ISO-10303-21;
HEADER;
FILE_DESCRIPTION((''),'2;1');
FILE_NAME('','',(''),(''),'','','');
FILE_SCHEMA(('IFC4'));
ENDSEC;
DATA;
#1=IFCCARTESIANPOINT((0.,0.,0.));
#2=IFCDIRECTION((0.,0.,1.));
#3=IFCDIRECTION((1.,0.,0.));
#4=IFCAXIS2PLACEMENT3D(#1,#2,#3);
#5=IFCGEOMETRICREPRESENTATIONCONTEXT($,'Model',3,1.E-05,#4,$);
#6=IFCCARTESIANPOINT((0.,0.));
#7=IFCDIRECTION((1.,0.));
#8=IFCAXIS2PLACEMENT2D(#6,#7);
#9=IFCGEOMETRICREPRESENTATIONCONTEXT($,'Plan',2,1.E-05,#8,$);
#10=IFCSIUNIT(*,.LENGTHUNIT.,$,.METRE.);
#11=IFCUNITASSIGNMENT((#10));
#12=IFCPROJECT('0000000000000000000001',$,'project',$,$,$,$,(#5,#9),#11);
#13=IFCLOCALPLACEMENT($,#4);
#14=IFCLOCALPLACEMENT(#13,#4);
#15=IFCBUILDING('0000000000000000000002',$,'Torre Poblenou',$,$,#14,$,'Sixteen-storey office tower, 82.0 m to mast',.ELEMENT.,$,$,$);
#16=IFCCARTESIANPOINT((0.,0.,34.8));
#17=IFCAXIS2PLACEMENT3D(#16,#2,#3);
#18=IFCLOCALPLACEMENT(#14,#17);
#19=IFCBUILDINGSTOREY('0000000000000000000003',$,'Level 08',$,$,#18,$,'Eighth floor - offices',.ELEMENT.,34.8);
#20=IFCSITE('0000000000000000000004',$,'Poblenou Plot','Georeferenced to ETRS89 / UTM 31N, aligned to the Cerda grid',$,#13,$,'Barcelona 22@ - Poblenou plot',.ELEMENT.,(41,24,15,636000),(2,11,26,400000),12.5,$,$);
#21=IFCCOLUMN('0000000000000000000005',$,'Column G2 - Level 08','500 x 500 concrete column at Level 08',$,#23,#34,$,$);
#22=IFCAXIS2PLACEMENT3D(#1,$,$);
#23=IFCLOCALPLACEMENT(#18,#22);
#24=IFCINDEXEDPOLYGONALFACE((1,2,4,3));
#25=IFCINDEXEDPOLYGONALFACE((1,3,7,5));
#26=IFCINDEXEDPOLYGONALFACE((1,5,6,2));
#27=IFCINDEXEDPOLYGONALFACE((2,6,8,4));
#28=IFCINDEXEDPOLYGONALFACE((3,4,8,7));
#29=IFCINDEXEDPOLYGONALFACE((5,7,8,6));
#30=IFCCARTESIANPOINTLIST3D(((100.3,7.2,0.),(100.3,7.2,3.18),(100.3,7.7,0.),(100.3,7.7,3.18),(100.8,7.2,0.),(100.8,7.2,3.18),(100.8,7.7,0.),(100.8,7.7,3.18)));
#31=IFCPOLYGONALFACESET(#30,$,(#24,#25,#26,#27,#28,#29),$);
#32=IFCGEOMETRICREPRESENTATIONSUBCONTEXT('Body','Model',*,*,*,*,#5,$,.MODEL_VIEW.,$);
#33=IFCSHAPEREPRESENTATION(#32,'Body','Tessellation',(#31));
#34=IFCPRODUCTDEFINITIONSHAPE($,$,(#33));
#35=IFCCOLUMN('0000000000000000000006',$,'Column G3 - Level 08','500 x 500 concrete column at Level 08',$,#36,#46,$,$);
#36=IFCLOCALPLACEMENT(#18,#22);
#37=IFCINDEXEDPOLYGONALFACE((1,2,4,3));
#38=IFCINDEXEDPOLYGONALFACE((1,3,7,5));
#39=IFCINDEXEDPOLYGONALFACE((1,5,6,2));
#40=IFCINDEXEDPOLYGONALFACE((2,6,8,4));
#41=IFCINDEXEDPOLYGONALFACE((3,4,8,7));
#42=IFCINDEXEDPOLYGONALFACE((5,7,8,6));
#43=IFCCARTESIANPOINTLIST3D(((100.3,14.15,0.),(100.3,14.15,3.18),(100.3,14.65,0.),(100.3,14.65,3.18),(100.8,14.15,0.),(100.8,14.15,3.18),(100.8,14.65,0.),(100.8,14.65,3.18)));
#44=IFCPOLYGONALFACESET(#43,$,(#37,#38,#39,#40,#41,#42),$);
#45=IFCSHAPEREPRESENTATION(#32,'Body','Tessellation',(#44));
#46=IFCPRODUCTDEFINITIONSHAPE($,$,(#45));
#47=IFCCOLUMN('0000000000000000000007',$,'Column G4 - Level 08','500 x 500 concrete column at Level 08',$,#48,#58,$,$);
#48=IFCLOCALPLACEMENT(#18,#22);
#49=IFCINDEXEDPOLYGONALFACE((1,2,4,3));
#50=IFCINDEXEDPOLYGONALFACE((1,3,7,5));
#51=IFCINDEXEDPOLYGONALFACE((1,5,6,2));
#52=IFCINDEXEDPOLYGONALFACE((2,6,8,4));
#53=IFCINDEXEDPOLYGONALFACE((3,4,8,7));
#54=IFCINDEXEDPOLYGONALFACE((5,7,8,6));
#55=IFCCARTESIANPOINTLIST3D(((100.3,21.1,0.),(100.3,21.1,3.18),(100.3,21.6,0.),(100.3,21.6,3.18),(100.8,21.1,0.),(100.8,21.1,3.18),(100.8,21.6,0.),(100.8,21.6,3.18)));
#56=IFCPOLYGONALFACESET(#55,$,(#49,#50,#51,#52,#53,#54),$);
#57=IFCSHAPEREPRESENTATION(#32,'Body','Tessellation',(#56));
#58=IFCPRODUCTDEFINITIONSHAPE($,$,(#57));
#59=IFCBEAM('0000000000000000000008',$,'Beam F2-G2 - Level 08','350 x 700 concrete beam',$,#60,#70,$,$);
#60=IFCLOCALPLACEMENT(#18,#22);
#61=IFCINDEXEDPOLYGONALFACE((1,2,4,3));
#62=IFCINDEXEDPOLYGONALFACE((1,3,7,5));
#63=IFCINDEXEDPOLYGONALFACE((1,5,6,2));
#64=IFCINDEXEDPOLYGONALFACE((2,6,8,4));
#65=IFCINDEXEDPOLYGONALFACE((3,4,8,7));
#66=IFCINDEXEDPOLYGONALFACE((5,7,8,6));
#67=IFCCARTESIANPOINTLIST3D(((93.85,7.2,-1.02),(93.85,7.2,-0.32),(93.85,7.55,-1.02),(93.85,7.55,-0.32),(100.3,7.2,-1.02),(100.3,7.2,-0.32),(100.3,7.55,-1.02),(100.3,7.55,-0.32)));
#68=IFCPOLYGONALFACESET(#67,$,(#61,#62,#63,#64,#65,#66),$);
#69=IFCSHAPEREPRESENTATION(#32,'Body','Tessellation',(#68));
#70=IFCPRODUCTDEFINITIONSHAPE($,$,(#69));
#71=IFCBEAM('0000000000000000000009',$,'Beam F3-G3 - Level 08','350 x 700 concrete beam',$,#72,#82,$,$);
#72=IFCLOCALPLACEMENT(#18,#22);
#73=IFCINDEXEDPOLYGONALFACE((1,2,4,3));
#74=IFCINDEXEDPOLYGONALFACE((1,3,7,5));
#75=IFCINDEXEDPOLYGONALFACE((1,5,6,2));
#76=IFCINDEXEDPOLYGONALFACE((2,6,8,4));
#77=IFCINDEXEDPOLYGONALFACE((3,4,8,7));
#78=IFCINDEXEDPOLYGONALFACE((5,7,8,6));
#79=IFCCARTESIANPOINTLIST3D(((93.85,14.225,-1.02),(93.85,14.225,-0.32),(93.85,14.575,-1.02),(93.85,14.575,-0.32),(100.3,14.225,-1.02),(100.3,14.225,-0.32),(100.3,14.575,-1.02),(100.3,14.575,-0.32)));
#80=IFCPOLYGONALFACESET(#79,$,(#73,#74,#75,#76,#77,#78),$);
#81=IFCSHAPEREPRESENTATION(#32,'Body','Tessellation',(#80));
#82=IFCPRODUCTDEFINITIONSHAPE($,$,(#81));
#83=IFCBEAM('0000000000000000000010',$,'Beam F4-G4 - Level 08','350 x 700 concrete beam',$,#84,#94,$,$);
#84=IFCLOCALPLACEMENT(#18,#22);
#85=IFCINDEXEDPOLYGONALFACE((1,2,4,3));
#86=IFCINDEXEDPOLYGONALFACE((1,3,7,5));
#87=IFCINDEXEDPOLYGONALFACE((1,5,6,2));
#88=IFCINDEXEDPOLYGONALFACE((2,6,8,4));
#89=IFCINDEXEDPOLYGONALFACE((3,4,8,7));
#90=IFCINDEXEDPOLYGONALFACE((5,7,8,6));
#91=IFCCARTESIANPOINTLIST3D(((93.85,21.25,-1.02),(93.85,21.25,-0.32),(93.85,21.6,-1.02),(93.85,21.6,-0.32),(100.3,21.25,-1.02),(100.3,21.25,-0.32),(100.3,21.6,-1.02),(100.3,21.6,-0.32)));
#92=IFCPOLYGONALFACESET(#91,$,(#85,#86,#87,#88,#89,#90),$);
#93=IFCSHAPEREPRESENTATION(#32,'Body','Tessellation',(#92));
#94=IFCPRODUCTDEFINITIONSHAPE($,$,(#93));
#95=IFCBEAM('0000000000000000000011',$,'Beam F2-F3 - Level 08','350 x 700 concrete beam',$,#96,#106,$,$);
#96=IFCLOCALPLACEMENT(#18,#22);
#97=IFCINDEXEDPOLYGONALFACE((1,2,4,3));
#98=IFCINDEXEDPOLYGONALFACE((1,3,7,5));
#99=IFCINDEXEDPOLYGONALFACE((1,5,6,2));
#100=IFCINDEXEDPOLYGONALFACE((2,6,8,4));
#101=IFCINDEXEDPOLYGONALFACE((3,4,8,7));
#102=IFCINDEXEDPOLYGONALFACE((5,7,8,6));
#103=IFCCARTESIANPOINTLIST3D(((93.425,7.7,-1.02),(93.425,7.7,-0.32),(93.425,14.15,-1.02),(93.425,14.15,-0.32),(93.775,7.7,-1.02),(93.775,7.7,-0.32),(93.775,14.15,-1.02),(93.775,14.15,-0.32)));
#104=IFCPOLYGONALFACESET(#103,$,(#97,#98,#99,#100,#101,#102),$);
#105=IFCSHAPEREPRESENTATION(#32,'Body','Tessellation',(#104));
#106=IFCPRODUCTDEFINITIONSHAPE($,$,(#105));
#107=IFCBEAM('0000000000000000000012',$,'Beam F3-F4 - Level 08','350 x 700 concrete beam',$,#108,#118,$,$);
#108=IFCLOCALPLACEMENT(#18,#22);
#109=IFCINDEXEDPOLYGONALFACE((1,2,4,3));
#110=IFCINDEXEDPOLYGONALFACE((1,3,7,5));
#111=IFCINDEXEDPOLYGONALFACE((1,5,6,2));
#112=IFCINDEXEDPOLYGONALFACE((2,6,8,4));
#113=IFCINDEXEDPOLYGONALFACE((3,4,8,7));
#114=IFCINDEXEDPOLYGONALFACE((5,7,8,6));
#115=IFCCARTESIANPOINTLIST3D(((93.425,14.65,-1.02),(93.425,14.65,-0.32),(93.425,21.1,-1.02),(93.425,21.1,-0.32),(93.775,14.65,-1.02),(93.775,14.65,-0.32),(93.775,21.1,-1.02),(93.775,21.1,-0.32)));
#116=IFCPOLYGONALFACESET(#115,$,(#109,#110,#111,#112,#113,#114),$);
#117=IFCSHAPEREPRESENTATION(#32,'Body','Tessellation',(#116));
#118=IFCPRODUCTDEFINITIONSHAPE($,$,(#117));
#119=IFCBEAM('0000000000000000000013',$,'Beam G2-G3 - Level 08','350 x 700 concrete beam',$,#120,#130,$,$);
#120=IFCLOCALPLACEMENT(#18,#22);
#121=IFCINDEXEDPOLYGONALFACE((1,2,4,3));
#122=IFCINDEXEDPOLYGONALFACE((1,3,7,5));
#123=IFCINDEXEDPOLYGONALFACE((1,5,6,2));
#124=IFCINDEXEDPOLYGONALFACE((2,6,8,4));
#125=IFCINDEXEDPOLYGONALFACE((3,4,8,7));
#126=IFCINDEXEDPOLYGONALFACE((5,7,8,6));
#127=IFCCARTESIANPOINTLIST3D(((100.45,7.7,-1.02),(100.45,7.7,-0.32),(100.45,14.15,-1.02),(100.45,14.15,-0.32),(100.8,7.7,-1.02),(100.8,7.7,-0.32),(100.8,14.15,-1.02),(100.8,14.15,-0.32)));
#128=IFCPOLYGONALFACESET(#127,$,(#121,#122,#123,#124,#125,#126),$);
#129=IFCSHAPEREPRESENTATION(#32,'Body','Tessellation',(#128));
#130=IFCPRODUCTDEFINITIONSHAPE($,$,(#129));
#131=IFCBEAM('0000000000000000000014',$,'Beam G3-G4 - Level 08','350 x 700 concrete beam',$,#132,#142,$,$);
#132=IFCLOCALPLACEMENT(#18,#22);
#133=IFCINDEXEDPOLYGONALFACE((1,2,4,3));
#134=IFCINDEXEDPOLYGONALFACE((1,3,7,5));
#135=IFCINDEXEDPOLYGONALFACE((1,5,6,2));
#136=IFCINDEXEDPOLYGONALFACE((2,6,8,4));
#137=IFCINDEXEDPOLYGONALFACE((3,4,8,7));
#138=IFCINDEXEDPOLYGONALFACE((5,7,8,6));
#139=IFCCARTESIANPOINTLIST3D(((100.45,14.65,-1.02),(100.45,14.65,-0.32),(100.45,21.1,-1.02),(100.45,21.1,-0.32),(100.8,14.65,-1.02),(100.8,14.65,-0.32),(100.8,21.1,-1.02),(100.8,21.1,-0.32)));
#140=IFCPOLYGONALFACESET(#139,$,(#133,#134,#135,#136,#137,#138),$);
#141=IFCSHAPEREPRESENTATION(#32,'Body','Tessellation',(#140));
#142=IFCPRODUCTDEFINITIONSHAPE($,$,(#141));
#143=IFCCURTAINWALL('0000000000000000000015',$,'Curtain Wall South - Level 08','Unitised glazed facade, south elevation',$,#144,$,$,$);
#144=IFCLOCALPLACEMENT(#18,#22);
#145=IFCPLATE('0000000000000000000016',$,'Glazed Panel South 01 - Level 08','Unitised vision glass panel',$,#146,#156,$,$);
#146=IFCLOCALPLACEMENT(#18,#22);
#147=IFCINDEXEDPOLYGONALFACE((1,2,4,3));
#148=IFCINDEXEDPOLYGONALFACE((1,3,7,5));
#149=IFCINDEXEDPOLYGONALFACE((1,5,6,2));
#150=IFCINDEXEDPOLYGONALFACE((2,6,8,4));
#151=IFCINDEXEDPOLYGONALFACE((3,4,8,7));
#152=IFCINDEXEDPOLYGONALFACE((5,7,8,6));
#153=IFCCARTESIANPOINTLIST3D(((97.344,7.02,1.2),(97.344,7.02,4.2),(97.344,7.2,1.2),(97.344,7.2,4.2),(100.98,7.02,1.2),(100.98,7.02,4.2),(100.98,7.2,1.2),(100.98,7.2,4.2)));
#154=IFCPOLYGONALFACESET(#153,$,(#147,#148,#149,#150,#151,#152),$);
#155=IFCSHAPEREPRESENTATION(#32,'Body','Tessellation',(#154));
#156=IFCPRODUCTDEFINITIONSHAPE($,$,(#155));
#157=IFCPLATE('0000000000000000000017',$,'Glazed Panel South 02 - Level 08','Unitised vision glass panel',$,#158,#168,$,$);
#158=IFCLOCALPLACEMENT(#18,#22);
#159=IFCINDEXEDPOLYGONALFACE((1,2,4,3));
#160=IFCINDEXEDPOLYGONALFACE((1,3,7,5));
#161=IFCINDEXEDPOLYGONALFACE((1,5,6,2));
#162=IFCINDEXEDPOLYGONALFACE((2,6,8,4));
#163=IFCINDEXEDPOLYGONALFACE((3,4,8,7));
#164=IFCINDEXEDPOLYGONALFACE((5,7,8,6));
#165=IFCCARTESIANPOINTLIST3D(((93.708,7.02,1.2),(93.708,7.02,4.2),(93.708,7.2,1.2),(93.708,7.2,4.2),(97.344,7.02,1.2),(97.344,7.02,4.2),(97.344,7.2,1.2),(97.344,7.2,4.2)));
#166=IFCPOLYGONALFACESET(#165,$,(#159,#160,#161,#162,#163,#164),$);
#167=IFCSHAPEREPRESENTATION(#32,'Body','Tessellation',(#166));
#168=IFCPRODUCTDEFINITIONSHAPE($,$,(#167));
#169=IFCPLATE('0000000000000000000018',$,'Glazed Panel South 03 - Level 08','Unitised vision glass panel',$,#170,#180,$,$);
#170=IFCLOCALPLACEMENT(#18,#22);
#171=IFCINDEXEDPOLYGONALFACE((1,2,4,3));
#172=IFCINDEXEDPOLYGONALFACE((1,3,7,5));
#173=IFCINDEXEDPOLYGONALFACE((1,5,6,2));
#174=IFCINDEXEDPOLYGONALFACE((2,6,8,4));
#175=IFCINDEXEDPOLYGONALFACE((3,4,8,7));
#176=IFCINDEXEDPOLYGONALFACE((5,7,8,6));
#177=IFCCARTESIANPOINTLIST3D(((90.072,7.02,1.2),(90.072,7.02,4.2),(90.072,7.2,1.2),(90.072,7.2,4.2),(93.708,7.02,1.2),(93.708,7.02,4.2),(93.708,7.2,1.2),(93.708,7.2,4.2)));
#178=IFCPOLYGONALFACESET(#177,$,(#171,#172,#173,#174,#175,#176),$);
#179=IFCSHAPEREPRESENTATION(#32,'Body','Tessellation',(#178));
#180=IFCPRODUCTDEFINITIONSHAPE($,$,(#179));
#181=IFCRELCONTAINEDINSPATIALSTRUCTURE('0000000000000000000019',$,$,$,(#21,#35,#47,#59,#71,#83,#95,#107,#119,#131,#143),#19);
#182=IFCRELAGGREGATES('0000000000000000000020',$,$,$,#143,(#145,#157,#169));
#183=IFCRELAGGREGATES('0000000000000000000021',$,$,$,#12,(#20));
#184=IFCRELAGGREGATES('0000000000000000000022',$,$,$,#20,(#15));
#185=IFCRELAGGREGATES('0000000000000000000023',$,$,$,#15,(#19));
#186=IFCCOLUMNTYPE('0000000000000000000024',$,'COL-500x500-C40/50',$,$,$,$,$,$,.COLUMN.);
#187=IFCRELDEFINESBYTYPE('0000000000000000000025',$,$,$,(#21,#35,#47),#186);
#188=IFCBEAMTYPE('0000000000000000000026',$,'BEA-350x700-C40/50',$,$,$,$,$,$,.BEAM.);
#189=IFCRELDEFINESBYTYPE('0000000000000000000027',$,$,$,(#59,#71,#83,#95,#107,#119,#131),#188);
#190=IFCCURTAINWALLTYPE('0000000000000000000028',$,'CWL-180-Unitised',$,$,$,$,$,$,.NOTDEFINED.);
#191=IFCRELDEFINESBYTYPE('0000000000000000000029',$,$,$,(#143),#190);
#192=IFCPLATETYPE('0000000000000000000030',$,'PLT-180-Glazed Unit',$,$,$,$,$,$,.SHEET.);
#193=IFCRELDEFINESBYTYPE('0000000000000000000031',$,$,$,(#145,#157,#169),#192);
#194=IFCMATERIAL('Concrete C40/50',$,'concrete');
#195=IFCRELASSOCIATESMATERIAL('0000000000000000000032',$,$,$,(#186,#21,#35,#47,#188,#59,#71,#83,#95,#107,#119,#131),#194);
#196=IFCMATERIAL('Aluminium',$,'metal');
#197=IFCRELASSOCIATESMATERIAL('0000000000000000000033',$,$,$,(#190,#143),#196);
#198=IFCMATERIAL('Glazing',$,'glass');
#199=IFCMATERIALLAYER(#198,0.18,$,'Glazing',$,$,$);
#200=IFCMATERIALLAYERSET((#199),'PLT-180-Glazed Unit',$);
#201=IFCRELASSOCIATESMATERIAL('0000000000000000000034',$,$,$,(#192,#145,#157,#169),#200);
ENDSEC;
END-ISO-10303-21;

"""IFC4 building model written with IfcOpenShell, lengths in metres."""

from ifc_helpers import new_model, si_unit, frame, origin_with_axes, origin_2d_with_axis, place, context, subcontext, project, spatial, line, indexed_curve, rectangle, outline, extrude, material, layer, layer_set, layer_usage, material_profile, profile_set, profile_usage, type_object, element, aggregate, save


model = new_model("IFC4")

# Units and contexts
model_context = context("Model", 3, precision=1e-05, world=origin_with_axes())
plan_context = context("Plan", 2, precision=1e-05, world=origin_2d_with_axis())
body_context = subcontext(model_context, "Body", "Model", "MODEL_VIEW")
ifc_project = project(units=[si_unit("LENGTHUNIT", "METRE")], contexts=[model_context, plan_context])

# Site, building, storey
site_placement = place(None, origin_with_axes())
site = spatial("IfcSite", under=ifc_project, at=site_placement, Name="Poblenou Plot", Description="Georeferenced to ETRS89 / UTM 31N, aligned to the Cerda grid", LongName="Barcelona 22@ - Poblenou plot", CompositionType="ELEMENT", RefLatitude=(41, 24, 15, 636000), RefLongitude=(2, 11, 26, 400000), RefElevation=12.5)
building_placement = place(site_placement, origin_with_axes())
building = spatial("IfcBuilding", under=site, at=building_placement, Name="Torre Poblenou", LongName="Sixteen-storey office tower, 82.0 m to mast", CompositionType="ELEMENT")
storey_placement = place(building_placement, frame((0.0, 0.0, 34.8), z_axis=(0.0, 0.0, 1.0), x_axis=(1.0, 0.0, 0.0)))
storey = spatial("IfcBuildingStorey", under=building, at=storey_placement, Name="Level 08", LongName="Eighth floor - offices", CompositionType="ELEMENT", Elevation=34.8)

# Columns
ifc_material_1 = material(Name="Concrete C40/50", Category="concrete")
ifc_material_profile_1 = material_profile(ifc_material_1, rectangle(XDim=0.5, YDim=0.5))
ifc_profile_set_1 = profile_set([ifc_material_profile_1], Name="COL-500x500-C40/50")
ifc_profile_usage_1 = profile_usage(ifc_profile_set_1)
column_type = type_object("IfcColumnType", Name="COL-500x500-C40/50", PredefinedType="COLUMN", material=ifc_profile_set_1)
column_1_placement = place(storey_placement, frame((100.3, 7.2, 0.0), z_axis=(0.0, 0.0, 1.0), x_axis=(1.0, 0.0, 0.0)))
element("IfcColumn", 1, at=column_1_placement, inside=storey, type_object=column_type, material=ifc_profile_usage_1, Name="Column G2 - Level 08", Description="500 x 500 concrete column at Level 08", context=body_context, shape_type="SweptSolid", body=[
    extrude(outline(indexed_curve([(0.0, 0.0), (0.5, 0.0), (0.5, 0.5), (0.0, 0.5)], segments=[line(1, 2, 3, 4, 1)])), origin_with_axes(), (0.0, 0.0, 1.0), 3.18),
])
ifc_profile_usage_2 = profile_usage(ifc_profile_set_1)
column_2_placement = place(storey_placement, frame((100.3, 14.15, 0.0), z_axis=(0.0, 0.0, 1.0), x_axis=(1.0, 0.0, 0.0)))
element("IfcColumn", 2, at=column_2_placement, inside=storey, type_object=column_type, material=ifc_profile_usage_2, Name="Column G3 - Level 08", Description="500 x 500 concrete column at Level 08", context=body_context, shape_type="SweptSolid", body=[
    extrude(outline(indexed_curve([(0.0, 0.0), (0.5, 0.0), (0.5, 0.5), (0.0, 0.5)], segments=[line(1, 2, 3, 4, 1)])), origin_with_axes(), (0.0, 0.0, 1.0), 3.18),
])
ifc_profile_usage_3 = profile_usage(ifc_profile_set_1)
column_3_placement = place(storey_placement, frame((100.3, 21.1, 0.0), z_axis=(0.0, 0.0, 1.0), x_axis=(1.0, 0.0, 0.0)))
element("IfcColumn", 3, at=column_3_placement, inside=storey, type_object=column_type, material=ifc_profile_usage_3, Name="Column G4 - Level 08", Description="500 x 500 concrete column at Level 08", context=body_context, shape_type="SweptSolid", body=[
    extrude(outline(indexed_curve([(0.0, 0.0), (0.5, 0.0), (0.5, 0.5), (0.0, 0.5)], segments=[line(1, 2, 3, 4, 1)])), origin_with_axes(), (0.0, 0.0, 1.0), 3.18),
])

# Beams
ifc_material_profile_2 = material_profile(ifc_material_1, rectangle(XDim=0.35, YDim=0.7))
ifc_profile_set_2 = profile_set([ifc_material_profile_2], Name="BEA-350x700-C40/50")
ifc_profile_usage_4 = profile_usage(ifc_profile_set_2)
beam_type = type_object("IfcBeamType", Name="BEA-350x700-C40/50", PredefinedType="BEAM", material=ifc_profile_set_2)
beam_1_placement = place(storey_placement, frame((93.85, 7.2, -1.02), z_axis=(0.0, 0.0, 1.0), x_axis=(1.0, 0.0, 0.0)))
element("IfcBeam", 4, at=beam_1_placement, inside=storey, type_object=beam_type, material=ifc_profile_usage_4, Name="Beam F2-G2 - Level 08", Description="350 x 700 concrete beam", context=body_context, shape_type="SweptSolid", body=[
    extrude(outline(indexed_curve([(0.0, 0.0), (6.45, 0.0), (6.45, 0.35), (0.0, 0.35)], segments=[line(1, 2, 3, 4, 1)])), origin_with_axes(), (0.0, 0.0, 1.0), 0.7),
])
ifc_profile_usage_5 = profile_usage(ifc_profile_set_2)
beam_2_placement = place(storey_placement, frame((93.85, 14.225, -1.02), z_axis=(0.0, 0.0, 1.0), x_axis=(1.0, 0.0, 0.0)))
element("IfcBeam", 5, at=beam_2_placement, inside=storey, type_object=beam_type, material=ifc_profile_usage_5, Name="Beam F3-G3 - Level 08", Description="350 x 700 concrete beam", context=body_context, shape_type="SweptSolid", body=[
    extrude(outline(indexed_curve([(0.0, 0.0), (6.45, 0.0), (6.45, 0.35), (0.0, 0.35)], segments=[line(1, 2, 3, 4, 1)])), origin_with_axes(), (0.0, 0.0, 1.0), 0.7),
])
ifc_profile_usage_6 = profile_usage(ifc_profile_set_2)
beam_3_placement = place(storey_placement, frame((93.85, 21.25, -1.02), z_axis=(0.0, 0.0, 1.0), x_axis=(1.0, 0.0, 0.0)))
element("IfcBeam", 6, at=beam_3_placement, inside=storey, type_object=beam_type, material=ifc_profile_usage_6, Name="Beam F4-G4 - Level 08", Description="350 x 700 concrete beam", context=body_context, shape_type="SweptSolid", body=[
    extrude(outline(indexed_curve([(0.0, 0.0), (6.45, 0.0), (6.45, 0.35), (0.0, 0.35)], segments=[line(1, 2, 3, 4, 1)])), origin_with_axes(), (0.0, 0.0, 1.0), 0.7),
])
ifc_profile_usage_7 = profile_usage(ifc_profile_set_2)
beam_4_placement = place(storey_placement, frame((93.775, 7.7, -1.02), z_axis=(0.0, 0.0, 1.0), x_axis=(0.0, 1.0, 0.0)))
element("IfcBeam", 7, at=beam_4_placement, inside=storey, type_object=beam_type, material=ifc_profile_usage_7, Name="Beam F2-F3 - Level 08", Description="350 x 700 concrete beam", context=body_context, shape_type="SweptSolid", body=[
    extrude(outline(indexed_curve([(0.0, 0.0), (6.45, 0.0), (6.45, 0.35), (0.0, 0.35)], segments=[line(1, 2, 3, 4, 1)])), origin_with_axes(), (0.0, 0.0, 1.0), 0.7),
])
ifc_profile_usage_8 = profile_usage(ifc_profile_set_2)
beam_5_placement = place(storey_placement, frame((93.775, 14.65, -1.02), z_axis=(0.0, 0.0, 1.0), x_axis=(0.0, 1.0, 0.0)))
element("IfcBeam", 8, at=beam_5_placement, inside=storey, type_object=beam_type, material=ifc_profile_usage_8, Name="Beam F3-F4 - Level 08", Description="350 x 700 concrete beam", context=body_context, shape_type="SweptSolid", body=[
    extrude(outline(indexed_curve([(0.0, 0.0), (6.45, 0.0), (6.45, 0.35), (0.0, 0.35)], segments=[line(1, 2, 3, 4, 1)])), origin_with_axes(), (0.0, 0.0, 1.0), 0.7),
])
ifc_profile_usage_9 = profile_usage(ifc_profile_set_2)
beam_6_placement = place(storey_placement, frame((100.8, 7.7, -1.02), z_axis=(0.0, 0.0, 1.0), x_axis=(0.0, 1.0, 0.0)))
element("IfcBeam", 9, at=beam_6_placement, inside=storey, type_object=beam_type, material=ifc_profile_usage_9, Name="Beam G2-G3 - Level 08", Description="350 x 700 concrete beam", context=body_context, shape_type="SweptSolid", body=[
    extrude(outline(indexed_curve([(0.0, 0.0), (6.45, 0.0), (6.45, 0.35), (0.0, 0.35)], segments=[line(1, 2, 3, 4, 1)])), origin_with_axes(), (0.0, 0.0, 1.0), 0.7),
])
ifc_profile_usage_10 = profile_usage(ifc_profile_set_2)
beam_7_placement = place(storey_placement, frame((100.8, 14.65, -1.02), z_axis=(0.0, 0.0, 1.0), x_axis=(0.0, 1.0, 0.0)))
element("IfcBeam", 10, at=beam_7_placement, inside=storey, type_object=beam_type, material=ifc_profile_usage_10, Name="Beam G3-G4 - Level 08", Description="350 x 700 concrete beam", context=body_context, shape_type="SweptSolid", body=[
    extrude(outline(indexed_curve([(0.0, 0.0), (6.45, 0.0), (6.45, 0.35), (0.0, 0.35)], segments=[line(1, 2, 3, 4, 1)])), origin_with_axes(), (0.0, 0.0, 1.0), 0.7),
])

# Curtain wall, plates
ifc_material_2 = material(Name="Aluminium", Category="metal")
curtain_wall_type = type_object("IfcCurtainWallType", Name="CWL-180-Unitised", PredefinedType="NOTDEFINED", material=ifc_material_2)
curtain_wall_1_placement = place(storey_placement, frame((100.98, 7.2, 0.0), z_axis=(0.0, 0.0, 1.0), x_axis=(-1.0, 0.0, 0.0)))
curtain_wall_1 = element("IfcCurtainWall", 11, at=curtain_wall_1_placement, inside=storey, type_object=curtain_wall_type, material=ifc_material_2, Name="Curtain Wall South - Level 08", Description="Unitised glazed facade, south elevation")
ifc_material_3 = material(Name="Glazing", Category="glass")
ifc_layer_1 = layer(ifc_material_3, 0.18, Name="Glazing")
ifc_layer_set_1 = layer_set([ifc_layer_1], Name="PLT-180-Glazed Unit")
ifc_layer_usage_1 = layer_usage(ifc_layer_set_1, "AXIS2", "POSITIVE", 0.0)
plate_type_1 = type_object("IfcPlateType", Name="PLT-180-Glazed Unit", PredefinedType="SHEET", material=ifc_layer_set_1)
plate_1_placement = place(curtain_wall_1_placement, frame((0.0, 0.0, 1.2), z_axis=(0.0, 0.0, 1.0), x_axis=(1.0, 0.0, 0.0)))
plate_1 = element("IfcPlate", 12, at=plate_1_placement, type_object=plate_type_1, material=ifc_layer_usage_1, Name="Glazed Panel South 01 - Level 08", Description="Unitised vision glass panel", context=body_context, shape_type="SweptSolid", body=[
    extrude(outline(indexed_curve([(0.0, 0.0), (3.636, 0.0), (3.636, 0.18), (0.0, 0.18)], segments=[line(1, 2, 3, 4, 1)])), origin_with_axes(), (0.0, 0.0, 1.0), 3.0),
])
ifc_layer_usage_2 = layer_usage(ifc_layer_set_1, "AXIS2", "POSITIVE", 0.0)
plate_2_placement = place(curtain_wall_1_placement, frame((3.636, 0.0, 1.2), z_axis=(0.0, 0.0, 1.0), x_axis=(1.0, 0.0, 0.0)))
plate_2 = element("IfcPlate", 13, at=plate_2_placement, type_object=plate_type_1, material=ifc_layer_usage_2, Name="Glazed Panel South 02 - Level 08", Description="Unitised vision glass panel", context=body_context, shape_type="SweptSolid", body=[
    extrude(outline(indexed_curve([(0.0, 0.0), (3.636, 0.0), (3.636, 0.18), (0.0, 0.18)], segments=[line(1, 2, 3, 4, 1)])), origin_with_axes(), (0.0, 0.0, 1.0), 3.0),
])
ifc_layer_usage_3 = layer_usage(ifc_layer_set_1, "AXIS2", "POSITIVE", 0.0)
plate_3_placement = place(curtain_wall_1_placement, frame((7.272, 0.0, 1.2), z_axis=(0.0, 0.0, 1.0), x_axis=(1.0, 0.0, 0.0)))
plate_3 = element("IfcPlate", 14, at=plate_3_placement, type_object=plate_type_1, material=ifc_layer_usage_3, Name="Glazed Panel South 03 - Level 08", Description="Unitised vision glass panel", context=body_context, shape_type="SweptSolid", body=[
    extrude(outline(indexed_curve([(0.0, 0.0), (3.636, 0.0), (3.636, 0.18), (0.0, 0.18)], segments=[line(1, 2, 3, 4, 1)])), origin_with_axes(), (0.0, 0.0, 1.0), 3.0),
])

aggregate(curtain_wall_1, [plate_1, plate_2, plate_3])

save(model, "model.ifc")
